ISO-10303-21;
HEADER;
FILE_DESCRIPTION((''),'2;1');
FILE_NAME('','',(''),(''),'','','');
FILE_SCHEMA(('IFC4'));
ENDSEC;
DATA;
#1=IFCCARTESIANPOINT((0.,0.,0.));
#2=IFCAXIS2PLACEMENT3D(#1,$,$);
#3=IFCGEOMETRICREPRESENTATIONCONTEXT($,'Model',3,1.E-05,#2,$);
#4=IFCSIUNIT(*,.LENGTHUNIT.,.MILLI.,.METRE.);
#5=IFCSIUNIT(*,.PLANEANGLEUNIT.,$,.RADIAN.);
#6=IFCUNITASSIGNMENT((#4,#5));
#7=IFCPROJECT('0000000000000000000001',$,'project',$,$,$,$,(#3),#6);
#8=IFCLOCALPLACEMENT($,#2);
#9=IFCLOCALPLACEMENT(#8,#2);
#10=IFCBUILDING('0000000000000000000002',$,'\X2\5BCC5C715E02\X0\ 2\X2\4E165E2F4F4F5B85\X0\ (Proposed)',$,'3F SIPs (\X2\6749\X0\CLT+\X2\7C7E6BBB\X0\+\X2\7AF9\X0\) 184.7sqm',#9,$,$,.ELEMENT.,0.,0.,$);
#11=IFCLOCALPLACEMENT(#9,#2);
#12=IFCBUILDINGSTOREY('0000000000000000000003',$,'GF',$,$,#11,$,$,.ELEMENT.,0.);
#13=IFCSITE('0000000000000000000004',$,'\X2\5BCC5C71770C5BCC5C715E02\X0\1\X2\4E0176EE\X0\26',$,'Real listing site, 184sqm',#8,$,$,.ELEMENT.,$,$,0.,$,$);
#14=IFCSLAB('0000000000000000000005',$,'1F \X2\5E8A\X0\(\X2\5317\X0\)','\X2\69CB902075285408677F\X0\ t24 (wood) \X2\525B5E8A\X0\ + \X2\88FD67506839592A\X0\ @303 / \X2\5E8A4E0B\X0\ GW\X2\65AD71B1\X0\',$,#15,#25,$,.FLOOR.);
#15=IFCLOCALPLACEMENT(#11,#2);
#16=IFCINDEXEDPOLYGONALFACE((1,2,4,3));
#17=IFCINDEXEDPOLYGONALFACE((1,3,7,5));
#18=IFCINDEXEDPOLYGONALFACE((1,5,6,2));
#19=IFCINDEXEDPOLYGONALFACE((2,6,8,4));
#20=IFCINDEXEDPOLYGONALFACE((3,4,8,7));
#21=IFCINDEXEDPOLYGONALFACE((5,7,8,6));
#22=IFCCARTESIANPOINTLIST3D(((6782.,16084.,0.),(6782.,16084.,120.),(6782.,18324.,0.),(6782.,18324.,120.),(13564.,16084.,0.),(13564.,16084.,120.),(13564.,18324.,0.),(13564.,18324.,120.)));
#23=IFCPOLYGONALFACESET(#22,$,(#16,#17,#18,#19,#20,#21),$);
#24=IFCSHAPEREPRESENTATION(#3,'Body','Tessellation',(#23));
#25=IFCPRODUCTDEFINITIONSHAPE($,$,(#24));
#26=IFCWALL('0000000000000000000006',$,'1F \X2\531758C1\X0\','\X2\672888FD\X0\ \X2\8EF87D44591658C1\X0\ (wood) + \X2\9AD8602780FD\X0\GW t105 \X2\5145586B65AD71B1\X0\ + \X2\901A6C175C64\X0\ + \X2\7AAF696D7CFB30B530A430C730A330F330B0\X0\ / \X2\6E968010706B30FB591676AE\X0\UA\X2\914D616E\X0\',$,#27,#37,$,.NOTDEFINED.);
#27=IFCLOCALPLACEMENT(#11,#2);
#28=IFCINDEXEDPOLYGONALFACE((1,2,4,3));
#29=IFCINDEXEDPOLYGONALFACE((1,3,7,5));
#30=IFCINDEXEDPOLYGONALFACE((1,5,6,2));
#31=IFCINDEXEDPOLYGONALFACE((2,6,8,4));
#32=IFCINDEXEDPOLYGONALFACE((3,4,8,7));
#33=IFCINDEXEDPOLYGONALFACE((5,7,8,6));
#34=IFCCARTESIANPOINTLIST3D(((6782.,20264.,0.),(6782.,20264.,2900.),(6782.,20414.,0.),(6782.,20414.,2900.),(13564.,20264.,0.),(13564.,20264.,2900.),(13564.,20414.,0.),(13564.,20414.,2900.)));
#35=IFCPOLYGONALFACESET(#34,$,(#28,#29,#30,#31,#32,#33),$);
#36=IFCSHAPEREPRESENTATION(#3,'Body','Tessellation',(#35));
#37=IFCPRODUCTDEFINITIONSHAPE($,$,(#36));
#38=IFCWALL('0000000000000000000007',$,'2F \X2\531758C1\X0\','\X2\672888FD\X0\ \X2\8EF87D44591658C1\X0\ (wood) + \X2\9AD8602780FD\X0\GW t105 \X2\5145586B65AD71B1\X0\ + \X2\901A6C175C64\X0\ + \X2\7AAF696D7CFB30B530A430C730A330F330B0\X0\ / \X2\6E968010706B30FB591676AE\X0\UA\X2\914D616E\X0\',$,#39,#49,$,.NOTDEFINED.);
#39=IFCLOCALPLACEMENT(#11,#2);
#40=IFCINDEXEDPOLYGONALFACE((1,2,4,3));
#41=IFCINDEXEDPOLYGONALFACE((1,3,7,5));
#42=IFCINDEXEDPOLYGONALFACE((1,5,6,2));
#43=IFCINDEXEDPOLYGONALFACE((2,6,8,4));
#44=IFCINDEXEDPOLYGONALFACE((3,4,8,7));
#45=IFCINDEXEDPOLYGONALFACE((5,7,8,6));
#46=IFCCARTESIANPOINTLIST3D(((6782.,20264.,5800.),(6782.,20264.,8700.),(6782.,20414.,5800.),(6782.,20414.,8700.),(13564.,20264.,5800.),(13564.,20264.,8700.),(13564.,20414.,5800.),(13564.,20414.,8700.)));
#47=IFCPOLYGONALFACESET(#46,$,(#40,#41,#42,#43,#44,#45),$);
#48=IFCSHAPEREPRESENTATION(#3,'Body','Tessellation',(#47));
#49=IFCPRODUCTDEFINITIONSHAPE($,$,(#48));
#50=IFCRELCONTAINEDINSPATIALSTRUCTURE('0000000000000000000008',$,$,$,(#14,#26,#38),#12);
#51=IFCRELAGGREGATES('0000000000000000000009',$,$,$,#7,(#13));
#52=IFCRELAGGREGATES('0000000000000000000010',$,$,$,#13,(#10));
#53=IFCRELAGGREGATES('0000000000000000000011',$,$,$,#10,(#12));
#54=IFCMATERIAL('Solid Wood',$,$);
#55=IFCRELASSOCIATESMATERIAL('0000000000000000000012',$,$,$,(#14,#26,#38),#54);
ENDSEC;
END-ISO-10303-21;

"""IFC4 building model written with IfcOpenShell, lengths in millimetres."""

from ifc_helpers import new_model, si_unit, frame, frame_2d, origin, place, context, project, spatial, rectangle, extrude, material, element, save


model = new_model("IFC4")

# Units and contexts
model_context = context("Model", 3, precision=1e-05, world=origin())
ifc_project = project(units=[si_unit("LENGTHUNIT", "METRE", prefix="MILLI"), si_unit("PLANEANGLEUNIT", "RADIAN")], contexts=[model_context])

# Site, building, storey
site_placement = place(None, origin())
site = spatial("IfcSite", under=ifc_project, at=site_placement, Name="富山県富山市1丁目26", ObjectType="Real listing site, 184sqm", CompositionType="ELEMENT", RefElevation=0.0)
building_placement = place(site_placement, origin())
building = spatial("IfcBuilding", under=site, at=building_placement, Name="富山市 2世帯住宅 (Proposed)", ObjectType="3F SIPs (杉CLT+籾殻+竹) 184.7sqm", CompositionType="ELEMENT", ElevationOfRefHeight=0.0, ElevationOfTerrain=0.0)
storey_placement = place(building_placement, origin())
storey = spatial("IfcBuildingStorey", under=building, at=storey_placement, Name="GF", CompositionType="ELEMENT", Elevation=0.0)

# Slab
ifc_material_1 = material(Name="Solid Wood")
slab_1_placement = place(storey_placement, frame((3391.0, 8042.0, 0.0)))
element("IfcSlab", 1, at=slab_1_placement, inside=storey, material=ifc_material_1, Name="1F 床(北)", Description="構造用合板 t24 (wood) 剛床 + 製材根太 @303 / 床下 GW断熱", PredefinedType="FLOOR", context=model_context, shape_type="SweptSolid", body=[
    extrude(rectangle(XDim=6782.0, YDim=2240.0, at=frame_2d((3391.0, 1120.0))), frame((3391.0, 8042.0, 0.0)), (0.0, 0.0, 1.0), 120.0),
])

# Wall
wall_1_placement = place(storey_placement, frame((3391.0, 10132.0, 0.0)))
element("IfcWall", 2, at=wall_1_placement, inside=storey, material=ifc_material_1, Name="1F 北壁", Description="木製 軸組外壁 (wood) + 高性能GW t105 充填断熱 + 通気層 + 窯業系サイディング / 準耐火・外皮UA配慮", PredefinedType="NOTDEFINED", context=model_context, shape_type="SweptSolid", body=[
    extrude(rectangle(XDim=6782.0, YDim=150.0, at=frame_2d((3391.0, 75.0))), frame((3391.0, 10132.0, 0.0)), (0.0, 0.0, 1.0), 2900.0),
])

# Wall
wall_2_placement = place(storey_placement, frame((3391.0, 10132.0, 2900.0)))
element("IfcWall", 3, at=wall_2_placement, inside=storey, material=ifc_material_1, Name="2F 北壁", Description="木製 軸組外壁 (wood) + 高性能GW t105 充填断熱 + 通気層 + 窯業系サイディング / 準耐火・外皮UA配慮", PredefinedType="NOTDEFINED", context=model_context, shape_type="SweptSolid", body=[
    extrude(rectangle(XDim=6782.0, YDim=150.0, at=frame_2d((3391.0, 75.0))), frame((3391.0, 10132.0, 2900.0)), (0.0, 0.0, 1.0), 2900.0),
])

save(model, "model.ifc")
